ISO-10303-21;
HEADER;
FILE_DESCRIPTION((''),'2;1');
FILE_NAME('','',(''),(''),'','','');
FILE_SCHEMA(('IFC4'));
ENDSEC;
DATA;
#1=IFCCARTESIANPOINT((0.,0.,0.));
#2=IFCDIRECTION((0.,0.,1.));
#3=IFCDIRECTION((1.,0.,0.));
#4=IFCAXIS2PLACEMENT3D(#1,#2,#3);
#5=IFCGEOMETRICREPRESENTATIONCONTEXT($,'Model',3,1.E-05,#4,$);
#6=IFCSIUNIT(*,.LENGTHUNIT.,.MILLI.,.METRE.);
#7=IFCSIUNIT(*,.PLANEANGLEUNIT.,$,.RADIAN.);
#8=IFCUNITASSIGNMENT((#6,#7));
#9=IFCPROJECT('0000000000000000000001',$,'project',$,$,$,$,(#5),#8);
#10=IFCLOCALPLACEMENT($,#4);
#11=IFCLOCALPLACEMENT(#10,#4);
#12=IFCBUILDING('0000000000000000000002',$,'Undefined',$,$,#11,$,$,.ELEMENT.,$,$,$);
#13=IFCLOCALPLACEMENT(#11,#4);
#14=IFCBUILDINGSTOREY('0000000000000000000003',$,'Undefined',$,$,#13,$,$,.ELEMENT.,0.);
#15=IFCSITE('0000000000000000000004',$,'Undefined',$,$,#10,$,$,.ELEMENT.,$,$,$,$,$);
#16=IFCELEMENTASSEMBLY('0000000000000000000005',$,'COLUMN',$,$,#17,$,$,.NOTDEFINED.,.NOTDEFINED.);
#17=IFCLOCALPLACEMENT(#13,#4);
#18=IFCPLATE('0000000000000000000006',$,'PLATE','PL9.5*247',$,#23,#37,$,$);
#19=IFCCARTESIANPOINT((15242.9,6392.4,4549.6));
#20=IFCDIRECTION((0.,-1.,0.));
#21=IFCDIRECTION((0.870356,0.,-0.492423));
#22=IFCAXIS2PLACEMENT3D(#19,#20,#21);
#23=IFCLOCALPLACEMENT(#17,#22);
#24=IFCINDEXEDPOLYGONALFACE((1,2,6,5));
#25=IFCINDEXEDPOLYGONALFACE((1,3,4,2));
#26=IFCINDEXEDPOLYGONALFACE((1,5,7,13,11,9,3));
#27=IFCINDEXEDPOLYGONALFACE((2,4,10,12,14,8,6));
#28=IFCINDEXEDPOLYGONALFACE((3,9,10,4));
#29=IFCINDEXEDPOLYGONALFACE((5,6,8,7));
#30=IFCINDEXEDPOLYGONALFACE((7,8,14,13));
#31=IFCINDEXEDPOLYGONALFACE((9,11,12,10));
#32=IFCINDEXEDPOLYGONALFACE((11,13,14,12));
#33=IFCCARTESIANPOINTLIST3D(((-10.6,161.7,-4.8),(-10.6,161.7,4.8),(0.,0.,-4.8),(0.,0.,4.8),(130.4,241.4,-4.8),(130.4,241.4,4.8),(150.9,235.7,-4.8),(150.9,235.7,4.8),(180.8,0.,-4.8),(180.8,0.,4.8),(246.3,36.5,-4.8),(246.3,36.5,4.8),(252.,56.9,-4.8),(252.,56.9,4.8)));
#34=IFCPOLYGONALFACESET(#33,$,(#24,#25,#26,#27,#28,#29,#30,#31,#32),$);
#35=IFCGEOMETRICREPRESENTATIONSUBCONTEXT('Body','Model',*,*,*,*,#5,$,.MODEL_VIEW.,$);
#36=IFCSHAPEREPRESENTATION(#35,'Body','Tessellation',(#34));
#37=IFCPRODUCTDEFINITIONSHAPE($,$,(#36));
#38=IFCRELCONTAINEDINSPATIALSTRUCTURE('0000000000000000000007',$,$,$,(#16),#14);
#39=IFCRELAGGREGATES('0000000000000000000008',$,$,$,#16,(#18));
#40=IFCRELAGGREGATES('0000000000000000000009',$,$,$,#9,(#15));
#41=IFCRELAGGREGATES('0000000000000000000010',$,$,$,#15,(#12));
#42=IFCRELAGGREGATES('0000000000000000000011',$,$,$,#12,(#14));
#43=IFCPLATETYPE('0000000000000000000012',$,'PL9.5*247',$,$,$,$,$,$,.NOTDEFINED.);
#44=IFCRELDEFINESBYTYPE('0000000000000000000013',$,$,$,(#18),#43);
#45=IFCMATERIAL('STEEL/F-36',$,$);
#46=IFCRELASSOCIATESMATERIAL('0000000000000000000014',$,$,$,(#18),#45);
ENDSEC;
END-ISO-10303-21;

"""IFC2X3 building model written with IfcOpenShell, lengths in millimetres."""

from ifc_helpers import new_model, si_unit, frame, origin_with_axes, place, context, subcontext, project, spatial, polyline, outline, extrude, material, type_object, element, aggregate, save


model = new_model("IFC2X3")

# Units and contexts
model_context = context("Model", 3, precision=1e-05, world=origin_with_axes())
body_context = subcontext(model_context, "Body", "Model", "MODEL_VIEW")
ifc_project = project(units=[si_unit("LENGTHUNIT", "METRE", prefix="MILLI"), si_unit("PLANEANGLEUNIT", "RADIAN")], contexts=[model_context])

# Site, building, storey
site_placement = place(None, origin_with_axes())
site = spatial("IfcSite", under=ifc_project, at=site_placement, Name="Undefined", CompositionType="ELEMENT")
building_placement = place(site_placement, origin_with_axes())
building = spatial("IfcBuilding", under=site, at=building_placement, Name="Undefined", CompositionType="ELEMENT")
storey_placement = place(building_placement, origin_with_axes())
storey = spatial("IfcBuildingStorey", under=building, at=storey_placement, Name="Undefined", CompositionType="ELEMENT", Elevation=0.0)

# Shared definitions
ifc_material_1 = material(Name="STEEL/F-36")

# Element assembly, plate
assembly_1_placement = place(storey_placement, origin_with_axes())
assembly_1 = element("IfcElementAssembly", 1, at=assembly_1_placement, inside=storey, Name="COLUMN", AssemblyPlace="NOTDEFINED", PredefinedType="NOTDEFINED")
plate_type_1 = type_object("IfcPlateType", Name="PL9.5*247", PredefinedType="NOTDEFINED")
plate_1_placement = place(assembly_1_placement, frame((15242.9, 6392.4, 4549.6), z_axis=(0.0, -1.0, 0.0), x_axis=(0.870356, 0.0, -0.492423)))
plate_1 = element("IfcPlate", 2, at=plate_1_placement, type_object=plate_type_1, material=ifc_material_1, Name="PLATE", Description="PL9.5*247", context=body_context, shape_type="SweptSolid", body=[
    extrude(outline(polyline([(0.0, 0.0), (180.8, 0.0), (246.3, 36.5), (252.0, 56.9), (150.9, 235.7), (130.4, 241.4), (-10.6, 161.7), (0.0, 0.0)])), frame((0.0, 0.0, -4.8), z_axis=(0.0, 0.0, 1.0), x_axis=(1.0, 0.0, 0.0)), (0.0, 0.0, 1.0), 9.5),
])

aggregate(assembly_1, [plate_1])

save(model, "model.ifc")
